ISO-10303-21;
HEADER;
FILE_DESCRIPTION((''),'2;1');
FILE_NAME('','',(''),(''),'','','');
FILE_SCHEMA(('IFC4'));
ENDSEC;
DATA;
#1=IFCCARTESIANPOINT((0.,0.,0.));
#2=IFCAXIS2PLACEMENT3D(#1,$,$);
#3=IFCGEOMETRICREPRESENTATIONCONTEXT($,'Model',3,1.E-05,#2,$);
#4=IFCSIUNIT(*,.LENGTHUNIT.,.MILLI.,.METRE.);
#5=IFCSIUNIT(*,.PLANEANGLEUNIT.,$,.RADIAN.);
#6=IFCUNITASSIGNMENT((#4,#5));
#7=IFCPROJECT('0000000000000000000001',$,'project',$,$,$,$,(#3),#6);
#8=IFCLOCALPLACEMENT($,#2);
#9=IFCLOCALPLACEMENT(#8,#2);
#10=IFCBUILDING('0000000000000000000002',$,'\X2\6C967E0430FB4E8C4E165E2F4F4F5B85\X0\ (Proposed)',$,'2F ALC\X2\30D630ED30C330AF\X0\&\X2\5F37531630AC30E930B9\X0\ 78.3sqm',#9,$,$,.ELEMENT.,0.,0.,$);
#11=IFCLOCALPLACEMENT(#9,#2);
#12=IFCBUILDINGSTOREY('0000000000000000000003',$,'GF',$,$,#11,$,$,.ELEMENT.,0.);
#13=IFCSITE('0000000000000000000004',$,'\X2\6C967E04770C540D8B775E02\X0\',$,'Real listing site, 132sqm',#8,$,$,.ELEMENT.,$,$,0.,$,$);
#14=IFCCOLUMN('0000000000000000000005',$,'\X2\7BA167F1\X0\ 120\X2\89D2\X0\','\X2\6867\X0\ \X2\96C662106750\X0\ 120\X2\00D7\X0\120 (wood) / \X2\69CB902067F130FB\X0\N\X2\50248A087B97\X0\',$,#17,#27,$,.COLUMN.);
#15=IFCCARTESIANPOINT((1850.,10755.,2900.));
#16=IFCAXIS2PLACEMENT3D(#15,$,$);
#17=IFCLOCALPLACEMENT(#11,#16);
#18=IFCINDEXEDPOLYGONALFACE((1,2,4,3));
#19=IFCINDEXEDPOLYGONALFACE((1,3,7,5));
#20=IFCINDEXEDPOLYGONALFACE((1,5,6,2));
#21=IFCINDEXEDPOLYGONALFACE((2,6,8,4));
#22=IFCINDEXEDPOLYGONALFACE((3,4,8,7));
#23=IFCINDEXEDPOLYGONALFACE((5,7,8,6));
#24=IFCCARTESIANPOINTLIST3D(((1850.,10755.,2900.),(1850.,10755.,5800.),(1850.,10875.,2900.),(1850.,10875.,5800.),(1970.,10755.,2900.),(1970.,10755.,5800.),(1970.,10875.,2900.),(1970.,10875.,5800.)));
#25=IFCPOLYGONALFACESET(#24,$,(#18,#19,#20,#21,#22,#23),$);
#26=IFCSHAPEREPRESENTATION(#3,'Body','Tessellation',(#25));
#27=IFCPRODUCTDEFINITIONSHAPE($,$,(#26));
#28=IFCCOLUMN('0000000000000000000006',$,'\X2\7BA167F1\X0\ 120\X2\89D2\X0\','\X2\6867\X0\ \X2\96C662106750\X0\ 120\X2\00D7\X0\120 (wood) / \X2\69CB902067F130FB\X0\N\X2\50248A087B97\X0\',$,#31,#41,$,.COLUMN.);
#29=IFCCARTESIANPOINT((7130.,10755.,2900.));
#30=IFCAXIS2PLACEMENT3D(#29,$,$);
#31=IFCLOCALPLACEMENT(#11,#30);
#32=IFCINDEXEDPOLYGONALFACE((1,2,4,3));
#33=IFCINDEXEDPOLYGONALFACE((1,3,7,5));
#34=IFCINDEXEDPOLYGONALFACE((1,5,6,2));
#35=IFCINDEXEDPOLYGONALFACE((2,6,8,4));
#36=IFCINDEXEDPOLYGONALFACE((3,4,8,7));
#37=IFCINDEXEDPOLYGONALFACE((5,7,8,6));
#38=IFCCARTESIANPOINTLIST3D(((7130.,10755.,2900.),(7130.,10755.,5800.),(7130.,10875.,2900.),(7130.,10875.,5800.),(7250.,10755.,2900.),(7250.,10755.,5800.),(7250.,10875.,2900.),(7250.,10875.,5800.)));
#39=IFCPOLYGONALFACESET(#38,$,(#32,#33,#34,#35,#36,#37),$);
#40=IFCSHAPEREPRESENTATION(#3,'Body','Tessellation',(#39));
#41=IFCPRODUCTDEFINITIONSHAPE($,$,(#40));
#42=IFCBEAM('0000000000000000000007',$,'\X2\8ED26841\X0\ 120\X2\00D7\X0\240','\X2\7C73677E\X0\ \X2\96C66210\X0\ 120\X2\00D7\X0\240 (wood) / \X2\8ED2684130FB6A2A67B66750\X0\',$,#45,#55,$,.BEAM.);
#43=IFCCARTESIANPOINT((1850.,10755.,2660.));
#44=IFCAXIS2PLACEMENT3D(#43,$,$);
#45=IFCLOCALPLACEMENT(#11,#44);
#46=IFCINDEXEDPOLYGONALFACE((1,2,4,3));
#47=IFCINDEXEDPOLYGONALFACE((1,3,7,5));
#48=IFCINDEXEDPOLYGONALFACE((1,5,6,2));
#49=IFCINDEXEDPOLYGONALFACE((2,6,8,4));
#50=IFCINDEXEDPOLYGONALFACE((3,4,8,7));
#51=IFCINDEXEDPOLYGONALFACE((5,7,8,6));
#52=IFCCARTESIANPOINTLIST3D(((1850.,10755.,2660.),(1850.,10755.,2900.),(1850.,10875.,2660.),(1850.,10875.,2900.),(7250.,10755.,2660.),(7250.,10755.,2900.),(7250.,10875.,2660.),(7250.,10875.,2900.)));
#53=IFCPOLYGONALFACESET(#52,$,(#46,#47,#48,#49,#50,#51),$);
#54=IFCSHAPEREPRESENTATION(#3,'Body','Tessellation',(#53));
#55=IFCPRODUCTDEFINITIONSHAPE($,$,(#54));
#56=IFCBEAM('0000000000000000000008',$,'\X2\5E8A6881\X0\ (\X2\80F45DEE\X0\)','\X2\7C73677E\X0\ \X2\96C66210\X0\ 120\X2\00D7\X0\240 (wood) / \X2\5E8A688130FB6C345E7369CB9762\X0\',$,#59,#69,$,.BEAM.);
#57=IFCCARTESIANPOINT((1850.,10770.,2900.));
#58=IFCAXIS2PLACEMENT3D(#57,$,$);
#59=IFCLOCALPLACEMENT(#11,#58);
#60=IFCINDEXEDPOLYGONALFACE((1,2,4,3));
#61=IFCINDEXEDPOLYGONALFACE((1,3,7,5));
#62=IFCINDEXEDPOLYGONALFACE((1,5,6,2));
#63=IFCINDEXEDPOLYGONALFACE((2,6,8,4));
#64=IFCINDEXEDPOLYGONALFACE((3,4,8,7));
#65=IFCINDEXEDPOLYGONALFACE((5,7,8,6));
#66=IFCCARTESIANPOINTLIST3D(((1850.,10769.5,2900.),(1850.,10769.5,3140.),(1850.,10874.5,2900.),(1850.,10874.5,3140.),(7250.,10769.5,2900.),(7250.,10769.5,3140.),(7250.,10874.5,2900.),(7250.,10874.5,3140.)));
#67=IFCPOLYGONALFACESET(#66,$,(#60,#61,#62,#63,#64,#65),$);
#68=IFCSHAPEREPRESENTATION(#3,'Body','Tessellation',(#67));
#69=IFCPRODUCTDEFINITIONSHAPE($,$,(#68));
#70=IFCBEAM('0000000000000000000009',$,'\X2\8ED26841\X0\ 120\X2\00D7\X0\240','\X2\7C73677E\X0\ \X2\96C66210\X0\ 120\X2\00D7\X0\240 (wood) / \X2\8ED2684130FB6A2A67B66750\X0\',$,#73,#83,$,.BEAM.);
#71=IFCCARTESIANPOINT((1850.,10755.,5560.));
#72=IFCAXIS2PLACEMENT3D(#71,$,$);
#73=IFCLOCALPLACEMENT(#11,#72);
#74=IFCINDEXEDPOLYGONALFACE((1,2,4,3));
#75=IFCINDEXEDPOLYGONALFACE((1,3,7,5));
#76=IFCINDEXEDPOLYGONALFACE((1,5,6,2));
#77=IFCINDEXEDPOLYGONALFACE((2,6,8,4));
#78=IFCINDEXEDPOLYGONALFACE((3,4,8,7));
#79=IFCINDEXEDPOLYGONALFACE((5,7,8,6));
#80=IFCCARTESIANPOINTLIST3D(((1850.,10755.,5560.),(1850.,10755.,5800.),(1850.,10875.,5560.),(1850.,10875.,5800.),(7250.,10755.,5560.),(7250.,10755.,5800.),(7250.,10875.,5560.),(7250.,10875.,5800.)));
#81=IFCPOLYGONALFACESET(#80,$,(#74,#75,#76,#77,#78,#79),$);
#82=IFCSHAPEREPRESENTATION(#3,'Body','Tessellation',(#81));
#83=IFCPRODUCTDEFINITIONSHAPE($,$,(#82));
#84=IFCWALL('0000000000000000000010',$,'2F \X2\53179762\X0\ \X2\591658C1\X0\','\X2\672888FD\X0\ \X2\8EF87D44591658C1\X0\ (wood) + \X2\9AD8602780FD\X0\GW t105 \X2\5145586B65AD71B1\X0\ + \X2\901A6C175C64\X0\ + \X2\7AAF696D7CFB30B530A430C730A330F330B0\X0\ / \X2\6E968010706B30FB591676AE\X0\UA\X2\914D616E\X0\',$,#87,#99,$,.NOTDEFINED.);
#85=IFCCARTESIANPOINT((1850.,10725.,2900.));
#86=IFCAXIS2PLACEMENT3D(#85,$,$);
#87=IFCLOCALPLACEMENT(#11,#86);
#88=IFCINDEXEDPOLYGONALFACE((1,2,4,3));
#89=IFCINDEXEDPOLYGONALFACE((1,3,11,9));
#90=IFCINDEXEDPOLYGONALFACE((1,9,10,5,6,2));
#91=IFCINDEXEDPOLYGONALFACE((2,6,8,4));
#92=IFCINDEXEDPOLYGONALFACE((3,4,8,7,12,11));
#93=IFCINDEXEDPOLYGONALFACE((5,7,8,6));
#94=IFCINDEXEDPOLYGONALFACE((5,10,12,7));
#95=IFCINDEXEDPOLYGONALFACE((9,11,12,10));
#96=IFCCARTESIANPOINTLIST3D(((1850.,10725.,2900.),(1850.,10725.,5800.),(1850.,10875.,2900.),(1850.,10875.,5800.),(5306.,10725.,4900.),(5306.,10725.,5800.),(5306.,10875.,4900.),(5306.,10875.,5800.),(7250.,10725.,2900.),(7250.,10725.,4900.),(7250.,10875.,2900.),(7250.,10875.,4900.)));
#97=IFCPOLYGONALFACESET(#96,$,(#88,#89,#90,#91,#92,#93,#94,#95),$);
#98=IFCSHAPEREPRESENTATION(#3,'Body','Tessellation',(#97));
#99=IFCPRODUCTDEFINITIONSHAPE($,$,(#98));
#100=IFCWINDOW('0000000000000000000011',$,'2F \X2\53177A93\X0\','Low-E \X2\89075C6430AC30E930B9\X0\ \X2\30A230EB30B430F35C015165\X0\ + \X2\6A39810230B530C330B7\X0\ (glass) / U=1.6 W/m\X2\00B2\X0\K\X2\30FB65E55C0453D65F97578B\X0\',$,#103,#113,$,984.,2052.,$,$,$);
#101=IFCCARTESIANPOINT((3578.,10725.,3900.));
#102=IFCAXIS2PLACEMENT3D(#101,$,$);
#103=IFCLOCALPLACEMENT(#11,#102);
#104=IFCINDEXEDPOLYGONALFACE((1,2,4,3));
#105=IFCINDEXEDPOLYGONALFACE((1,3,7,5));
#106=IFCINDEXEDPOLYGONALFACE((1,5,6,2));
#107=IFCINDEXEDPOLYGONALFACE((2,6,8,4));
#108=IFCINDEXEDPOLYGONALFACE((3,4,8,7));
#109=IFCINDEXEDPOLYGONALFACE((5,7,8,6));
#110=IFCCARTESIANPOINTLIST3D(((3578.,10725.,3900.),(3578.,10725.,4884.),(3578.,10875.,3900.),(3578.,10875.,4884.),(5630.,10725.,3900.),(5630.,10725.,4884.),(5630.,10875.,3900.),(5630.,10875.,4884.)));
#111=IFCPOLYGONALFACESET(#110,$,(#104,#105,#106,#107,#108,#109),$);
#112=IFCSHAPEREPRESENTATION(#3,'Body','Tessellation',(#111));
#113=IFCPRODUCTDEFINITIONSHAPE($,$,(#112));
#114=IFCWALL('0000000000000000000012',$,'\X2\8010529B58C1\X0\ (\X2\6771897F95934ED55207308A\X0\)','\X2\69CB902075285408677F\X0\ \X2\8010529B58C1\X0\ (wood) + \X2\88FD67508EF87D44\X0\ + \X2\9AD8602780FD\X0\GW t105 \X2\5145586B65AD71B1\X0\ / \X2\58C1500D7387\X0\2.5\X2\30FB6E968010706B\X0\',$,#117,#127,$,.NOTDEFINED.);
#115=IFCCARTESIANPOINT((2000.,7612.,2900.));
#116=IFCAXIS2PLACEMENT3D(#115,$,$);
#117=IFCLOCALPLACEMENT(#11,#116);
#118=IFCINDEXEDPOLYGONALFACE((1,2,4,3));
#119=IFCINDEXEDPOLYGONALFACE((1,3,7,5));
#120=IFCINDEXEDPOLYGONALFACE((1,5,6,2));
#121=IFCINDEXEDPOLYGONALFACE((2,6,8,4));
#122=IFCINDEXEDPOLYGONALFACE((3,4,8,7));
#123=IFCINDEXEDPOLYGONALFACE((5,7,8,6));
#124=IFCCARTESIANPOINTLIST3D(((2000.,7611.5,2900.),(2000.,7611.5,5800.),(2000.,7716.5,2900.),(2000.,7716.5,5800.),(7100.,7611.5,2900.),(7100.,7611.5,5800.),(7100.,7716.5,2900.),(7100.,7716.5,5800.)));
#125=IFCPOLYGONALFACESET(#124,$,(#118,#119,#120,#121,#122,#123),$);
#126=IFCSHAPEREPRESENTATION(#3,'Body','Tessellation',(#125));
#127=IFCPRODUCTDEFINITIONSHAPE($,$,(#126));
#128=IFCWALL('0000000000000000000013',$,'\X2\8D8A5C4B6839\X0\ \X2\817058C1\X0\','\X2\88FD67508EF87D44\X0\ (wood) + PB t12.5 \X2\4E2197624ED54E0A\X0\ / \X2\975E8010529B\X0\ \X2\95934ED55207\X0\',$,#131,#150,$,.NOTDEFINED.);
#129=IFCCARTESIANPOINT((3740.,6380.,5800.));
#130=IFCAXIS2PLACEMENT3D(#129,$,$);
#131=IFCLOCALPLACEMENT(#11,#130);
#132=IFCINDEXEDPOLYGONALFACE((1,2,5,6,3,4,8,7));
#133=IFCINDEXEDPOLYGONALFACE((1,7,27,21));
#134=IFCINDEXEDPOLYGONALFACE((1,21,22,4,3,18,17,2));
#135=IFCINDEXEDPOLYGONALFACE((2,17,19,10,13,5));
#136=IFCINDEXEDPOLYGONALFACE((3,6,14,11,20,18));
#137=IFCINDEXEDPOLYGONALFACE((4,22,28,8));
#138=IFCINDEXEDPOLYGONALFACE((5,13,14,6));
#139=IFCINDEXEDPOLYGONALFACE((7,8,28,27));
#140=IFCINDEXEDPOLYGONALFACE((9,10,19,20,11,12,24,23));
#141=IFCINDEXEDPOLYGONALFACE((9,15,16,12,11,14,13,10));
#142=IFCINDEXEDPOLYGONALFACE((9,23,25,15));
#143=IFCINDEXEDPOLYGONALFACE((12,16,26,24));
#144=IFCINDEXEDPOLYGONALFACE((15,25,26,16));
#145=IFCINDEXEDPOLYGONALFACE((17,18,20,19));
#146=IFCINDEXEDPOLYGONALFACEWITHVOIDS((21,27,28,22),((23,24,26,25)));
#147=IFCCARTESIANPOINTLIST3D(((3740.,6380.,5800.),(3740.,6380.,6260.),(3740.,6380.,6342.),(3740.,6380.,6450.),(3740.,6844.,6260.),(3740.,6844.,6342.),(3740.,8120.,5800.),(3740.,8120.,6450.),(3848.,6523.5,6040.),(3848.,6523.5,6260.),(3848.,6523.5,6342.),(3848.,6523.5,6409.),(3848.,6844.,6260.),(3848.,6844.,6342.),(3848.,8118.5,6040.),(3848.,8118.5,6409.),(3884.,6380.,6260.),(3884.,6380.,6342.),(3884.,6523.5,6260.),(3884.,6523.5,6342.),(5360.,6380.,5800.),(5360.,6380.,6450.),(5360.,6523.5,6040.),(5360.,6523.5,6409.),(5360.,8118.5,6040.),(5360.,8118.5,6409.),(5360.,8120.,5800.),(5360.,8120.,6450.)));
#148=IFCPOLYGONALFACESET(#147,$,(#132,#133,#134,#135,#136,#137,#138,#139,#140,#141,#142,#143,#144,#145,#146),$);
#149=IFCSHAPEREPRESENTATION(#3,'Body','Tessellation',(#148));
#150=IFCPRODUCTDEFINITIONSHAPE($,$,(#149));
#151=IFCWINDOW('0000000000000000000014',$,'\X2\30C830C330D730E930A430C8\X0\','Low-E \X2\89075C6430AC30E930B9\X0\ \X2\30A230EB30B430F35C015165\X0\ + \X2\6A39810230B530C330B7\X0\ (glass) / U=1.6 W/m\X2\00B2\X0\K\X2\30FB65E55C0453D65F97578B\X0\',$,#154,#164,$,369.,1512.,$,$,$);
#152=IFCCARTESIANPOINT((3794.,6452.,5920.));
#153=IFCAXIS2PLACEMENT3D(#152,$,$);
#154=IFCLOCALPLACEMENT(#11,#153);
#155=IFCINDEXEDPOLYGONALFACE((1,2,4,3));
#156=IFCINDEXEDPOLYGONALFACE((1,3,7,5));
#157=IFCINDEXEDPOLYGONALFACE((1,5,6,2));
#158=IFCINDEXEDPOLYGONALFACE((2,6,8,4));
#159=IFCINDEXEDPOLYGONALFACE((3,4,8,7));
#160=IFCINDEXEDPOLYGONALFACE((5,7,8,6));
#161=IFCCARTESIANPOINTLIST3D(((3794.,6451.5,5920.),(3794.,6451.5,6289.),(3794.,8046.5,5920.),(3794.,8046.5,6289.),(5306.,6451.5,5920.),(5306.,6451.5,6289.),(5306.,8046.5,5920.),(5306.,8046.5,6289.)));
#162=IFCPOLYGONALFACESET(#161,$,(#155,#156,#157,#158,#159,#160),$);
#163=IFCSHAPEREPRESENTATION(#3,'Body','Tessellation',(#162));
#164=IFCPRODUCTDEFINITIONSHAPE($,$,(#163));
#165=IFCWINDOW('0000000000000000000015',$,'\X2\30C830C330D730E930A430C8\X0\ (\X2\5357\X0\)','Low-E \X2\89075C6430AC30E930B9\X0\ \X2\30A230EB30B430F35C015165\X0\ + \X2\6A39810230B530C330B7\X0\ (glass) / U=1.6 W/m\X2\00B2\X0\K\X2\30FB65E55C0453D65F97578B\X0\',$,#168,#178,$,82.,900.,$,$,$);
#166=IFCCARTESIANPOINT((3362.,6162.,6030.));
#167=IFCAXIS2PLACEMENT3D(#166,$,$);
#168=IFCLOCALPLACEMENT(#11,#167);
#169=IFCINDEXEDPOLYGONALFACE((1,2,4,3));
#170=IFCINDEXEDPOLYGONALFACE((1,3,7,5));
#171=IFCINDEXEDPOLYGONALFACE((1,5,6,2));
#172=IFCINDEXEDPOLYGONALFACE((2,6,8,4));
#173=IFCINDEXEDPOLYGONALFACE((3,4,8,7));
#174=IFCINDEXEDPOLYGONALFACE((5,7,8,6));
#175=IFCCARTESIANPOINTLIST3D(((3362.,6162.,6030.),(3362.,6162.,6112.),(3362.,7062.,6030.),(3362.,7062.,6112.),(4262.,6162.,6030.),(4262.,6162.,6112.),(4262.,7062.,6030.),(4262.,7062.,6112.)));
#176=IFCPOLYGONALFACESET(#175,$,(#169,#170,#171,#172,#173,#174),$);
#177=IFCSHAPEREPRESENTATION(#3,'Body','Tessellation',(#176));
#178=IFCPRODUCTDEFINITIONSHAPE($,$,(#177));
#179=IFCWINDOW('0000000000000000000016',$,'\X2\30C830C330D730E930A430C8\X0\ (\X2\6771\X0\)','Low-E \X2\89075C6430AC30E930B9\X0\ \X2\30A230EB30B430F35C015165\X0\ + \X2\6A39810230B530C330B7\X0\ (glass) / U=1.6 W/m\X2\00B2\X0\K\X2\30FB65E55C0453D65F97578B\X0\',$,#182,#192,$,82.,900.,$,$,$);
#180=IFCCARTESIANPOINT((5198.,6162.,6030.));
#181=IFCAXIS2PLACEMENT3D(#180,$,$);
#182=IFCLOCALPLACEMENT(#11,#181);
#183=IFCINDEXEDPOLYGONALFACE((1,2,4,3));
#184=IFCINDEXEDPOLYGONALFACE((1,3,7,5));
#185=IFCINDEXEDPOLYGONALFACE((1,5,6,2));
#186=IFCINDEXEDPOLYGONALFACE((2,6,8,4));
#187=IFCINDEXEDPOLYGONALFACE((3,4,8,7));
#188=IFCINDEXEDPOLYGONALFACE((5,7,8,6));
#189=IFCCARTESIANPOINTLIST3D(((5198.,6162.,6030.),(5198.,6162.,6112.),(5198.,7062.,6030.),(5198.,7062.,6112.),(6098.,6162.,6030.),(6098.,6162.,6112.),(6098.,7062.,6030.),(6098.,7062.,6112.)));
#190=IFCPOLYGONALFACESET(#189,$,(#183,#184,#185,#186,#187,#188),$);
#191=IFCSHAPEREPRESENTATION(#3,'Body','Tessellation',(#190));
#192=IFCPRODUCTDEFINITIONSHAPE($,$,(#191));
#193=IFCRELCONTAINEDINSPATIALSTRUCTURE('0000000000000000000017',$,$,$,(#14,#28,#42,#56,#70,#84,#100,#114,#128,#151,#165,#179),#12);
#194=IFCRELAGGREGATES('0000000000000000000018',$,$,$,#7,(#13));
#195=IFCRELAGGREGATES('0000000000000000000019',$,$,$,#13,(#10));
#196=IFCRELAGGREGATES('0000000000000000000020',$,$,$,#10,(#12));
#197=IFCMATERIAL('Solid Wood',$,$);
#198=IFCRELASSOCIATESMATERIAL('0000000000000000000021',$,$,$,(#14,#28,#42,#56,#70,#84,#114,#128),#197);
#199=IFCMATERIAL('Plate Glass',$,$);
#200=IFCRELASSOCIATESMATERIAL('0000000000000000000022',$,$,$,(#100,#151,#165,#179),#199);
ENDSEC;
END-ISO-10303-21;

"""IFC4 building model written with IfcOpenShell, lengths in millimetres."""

from ifc_helpers import new_model, si_unit, frame, frame_2d, origin, place, context, project, spatial, rectangle, extrude, material, element, fill, save


model = new_model("IFC4")

# Units and contexts
model_context = context("Model", 3, precision=1e-05, world=origin())
ifc_project = project(units=[si_unit("LENGTHUNIT", "METRE", prefix="MILLI"), si_unit("PLANEANGLEUNIT", "RADIAN")], contexts=[model_context])

# Site, building, storey
site_placement = place(None, origin())
site = spatial("IfcSite", under=ifc_project, at=site_placement, Name="沖縄県名護市", ObjectType="Real listing site, 132sqm", CompositionType="ELEMENT", RefElevation=0.0)
building_placement = place(site_placement, origin())
building = spatial("IfcBuilding", under=site, at=building_placement, Name="沖縄・二世帯住宅 (Proposed)", ObjectType="2F ALCブロック&強化ガラス 78.3sqm", CompositionType="ELEMENT", ElevationOfRefHeight=0.0, ElevationOfTerrain=0.0)
storey_placement = place(building_placement, origin())
storey = spatial("IfcBuildingStorey", under=building, at=storey_placement, Name="GF", CompositionType="ELEMENT", Elevation=0.0)

# Columns
ifc_material_1 = material(Name="Solid Wood")
column_1_placement = place(storey_placement, frame((1850.0, 10755.0, 2900.0)))
element("IfcColumn", 1, at=column_1_placement, inside=storey, material=ifc_material_1, Name="管柱 120角", Description="桧 集成材 120×120 (wood) / 構造柱・N値計算", PredefinedType="COLUMN", context=model_context, shape_type="SweptSolid", body=[
    extrude(rectangle(XDim=120.0, YDim=120.0, at=frame_2d((60.0, 60.0))), frame((1850.0, 10755.0, 2900.0)), (0.0, 0.0, 1.0), 2900.0),
])
column_2_placement = place(storey_placement, frame((7130.0, 10755.0, 2900.0)))
element("IfcColumn", 2, at=column_2_placement, inside=storey, material=ifc_material_1, Name="管柱 120角", Description="桧 集成材 120×120 (wood) / 構造柱・N値計算", PredefinedType="COLUMN", context=model_context, shape_type="SweptSolid", body=[
    extrude(rectangle(XDim=120.0, YDim=120.0, at=frame_2d((60.0, 60.0))), frame((7130.0, 10755.0, 2900.0)), (0.0, 0.0, 1.0), 2900.0),
])

# Beams
beam_1_placement = place(storey_placement, frame((1850.0, 10755.0, 2660.0)))
element("IfcBeam", 3, at=beam_1_placement, inside=storey, material=ifc_material_1, Name="軒桁 120×240", Description="米松 集成 120×240 (wood) / 軒桁・横架材", PredefinedType="BEAM", context=model_context, shape_type="SweptSolid", body=[
    extrude(rectangle(XDim=5400.0, YDim=120.0, at=frame_2d((2700.0, 60.0))), frame((1850.0, 10755.0, 2660.0)), (0.0, 0.0, 1.0), 240.0),
])
beam_2_placement = place(storey_placement, frame((1850.0, 10770.0, 2900.0)))
element("IfcBeam", 4, at=beam_2_placement, inside=storey, material=ifc_material_1, Name="床梁 (胴差)", Description="米松 集成 120×240 (wood) / 床梁・水平構面", PredefinedType="BEAM", context=model_context, shape_type="SweptSolid", body=[
    extrude(rectangle(XDim=5400.0, YDim=105.0, at=frame_2d((2700.0, 52.0))), frame((1850.0, 10770.0, 2900.0)), (0.0, 0.0, 1.0), 240.0),
])
beam_3_placement = place(storey_placement, frame((1850.0, 10755.0, 5560.0)))
element("IfcBeam", 5, at=beam_3_placement, inside=storey, material=ifc_material_1, Name="軒桁 120×240", Description="米松 集成 120×240 (wood) / 軒桁・横架材", PredefinedType="BEAM", context=model_context, shape_type="SweptSolid", body=[
    extrude(rectangle(XDim=5400.0, YDim=120.0, at=frame_2d((2700.0, 60.0))), frame((1850.0, 10755.0, 5560.0)), (0.0, 0.0, 1.0), 240.0),
])

# Wall, opening, window
wall_1_placement = place(storey_placement, frame((1850.0, 10725.0, 2900.0)))
wall_1 = element("IfcWall", 6, at=wall_1_placement, inside=storey, material=ifc_material_1, Name="2F 北面 外壁", Description="木製 軸組外壁 (wood) + 高性能GW t105 充填断熱 + 通気層 + 窯業系サイディング / 準耐火・外皮UA配慮", PredefinedType="NOTDEFINED", context=model_context, shape_type="SweptSolid", body=[
    extrude(rectangle(XDim=5400.0, YDim=150.0, at=frame_2d((2700.0, 75.0))), frame((1850.0, 10725.0, 2900.0)), (0.0, 0.0, 1.0), 2900.0),
])
opening_1_placement = place(storey_placement, frame((3578.0, 10725.0, 3900.0)))
opening_1 = element("IfcOpeningElement", 7, at=opening_1_placement, cuts=wall_1, PredefinedType="NOTDEFINED", context=model_context, shape_type="SweptSolid", body=[
    extrude(rectangle(XDim=2052.0, YDim=150.0, at=frame_2d((1026.0, 75.0))), frame((3578.0, 10725.0, 3900.0)), (0.0, 0.0, 1.0), 984.0),
])
ifc_material_2 = material(Name="Plate Glass")
window_1_placement = place(storey_placement, frame((3578.0, 10725.0, 3900.0)))
window_1 = element("IfcWindow", 8, at=window_1_placement, inside=storey, material=ifc_material_2, Name="2F 北窓", Description="Low-E 複層ガラス アルゴン封入 + 樹脂サッシ (glass) / U=1.6 W/m²K・日射取得型", OverallHeight=984.0, OverallWidth=2052.0, context=model_context, shape_type="SweptSolid", body=[
    extrude(rectangle(XDim=2052.0, YDim=150.0, at=frame_2d((1026.0, 75.0))), frame((3578.0, 10725.0, 3900.0)), (0.0, 0.0, 1.0), 984.0),
])
fill(opening_1, window_1)

# Wall
wall_2_placement = place(storey_placement, frame((2000.0, 7612.0, 2900.0)))
element("IfcWall", 9, at=wall_2_placement, inside=storey, material=ifc_material_1, Name="耐力壁 (東西間仕切り)", Description="構造用合板 耐力壁 (wood) + 製材軸組 + 高性能GW t105 充填断熱 / 壁倍率2.5・準耐火", PredefinedType="NOTDEFINED", context=model_context, shape_type="SweptSolid", body=[
    extrude(rectangle(XDim=5100.0, YDim=105.0, at=frame_2d((2550.0, 52.0))), frame((2000.0, 7612.0, 2900.0)), (0.0, 0.0, 1.0), 2900.0),
])

# Wall, openings, windows
wall_3_placement = place(storey_placement, frame((3740.0, 6380.0, 5800.0)))
wall_3 = element("IfcWall", 10, at=wall_3_placement, inside=storey, material=ifc_material_1, Name="越屋根 腰壁", Description="製材軸組 (wood) + PB t12.5 両面仕上 / 非耐力 間仕切", PredefinedType="NOTDEFINED", context=model_context, shape_type="SweptSolid", body=[
    extrude(rectangle(XDim=1620.0, YDim=1740.0, at=frame_2d((810.0, 870.0))), frame((3740.0, 6380.0, 5800.0)), (0.0, 0.0, 1.0), 650.0),
])
opening_2_placement = place(storey_placement, frame((3794.0, 6452.0, 5920.0)))
opening_2 = element("IfcOpeningElement", 11, at=opening_2_placement, cuts=wall_3, PredefinedType="NOTDEFINED", context=model_context, shape_type="SweptSolid", body=[
    extrude(rectangle(XDim=1512.0, YDim=1595.0, at=frame_2d((756.0, 797.0))), frame((3794.0, 6452.0, 5920.0)), (0.0, 0.0, 1.0), 369.0),
])
opening_3_placement = place(storey_placement, frame((3362.0, 6162.0, 6030.0)))
opening_3 = element("IfcOpeningElement", 12, at=opening_3_placement, cuts=wall_3, PredefinedType="NOTDEFINED", context=model_context, shape_type="SweptSolid", body=[
    extrude(rectangle(XDim=900.0, YDim=900.0, at=frame_2d((450.0, 450.0))), frame((3362.0, 6162.0, 6030.0)), (0.0, 0.0, 1.0), 82.0),
])
opening_4_placement = place(storey_placement, frame((5198.0, 6162.0, 6030.0)))
opening_4 = element("IfcOpeningElement", 13, at=opening_4_placement, cuts=wall_3, PredefinedType="NOTDEFINED", context=model_context, shape_type="SweptSolid", body=[
    extrude(rectangle(XDim=900.0, YDim=900.0, at=frame_2d((450.0, 450.0))), frame((5198.0, 6162.0, 6030.0)), (0.0, 0.0, 1.0), 82.0),
])
window_2_placement = place(storey_placement, frame((3794.0, 6452.0, 5920.0)))
window_2 = element("IfcWindow", 14, at=window_2_placement, inside=storey, material=ifc_material_2, Name="トップライト", Description="Low-E 複層ガラス アルゴン封入 + 樹脂サッシ (glass) / U=1.6 W/m²K・日射取得型", OverallHeight=369.0, OverallWidth=1512.0, context=model_context, shape_type="SweptSolid", body=[
    extrude(rectangle(XDim=1512.0, YDim=1595.0, at=frame_2d((756.0, 797.0))), frame((3794.0, 6452.0, 5920.0)), (0.0, 0.0, 1.0), 369.0),
])
fill(opening_2, window_2)
window_3_placement = place(storey_placement, frame((3362.0, 6162.0, 6030.0)))
window_3 = element("IfcWindow", 15, at=window_3_placement, inside=storey, material=ifc_material_2, Name="トップライト (南)", Description="Low-E 複層ガラス アルゴン封入 + 樹脂サッシ (glass) / U=1.6 W/m²K・日射取得型", OverallHeight=82.0, OverallWidth=900.0, context=model_context, shape_type="SweptSolid", body=[
    extrude(rectangle(XDim=900.0, YDim=900.0, at=frame_2d((450.0, 450.0))), frame((3362.0, 6162.0, 6030.0)), (0.0, 0.0, 1.0), 82.0),
])
fill(opening_3, window_3)
window_4_placement = place(storey_placement, frame((5198.0, 6162.0, 6030.0)))
window_4 = element("IfcWindow", 16, at=window_4_placement, inside=storey, material=ifc_material_2, Name="トップライト (東)", Description="Low-E 複層ガラス アルゴン封入 + 樹脂サッシ (glass) / U=1.6 W/m²K・日射取得型", OverallHeight=82.0, OverallWidth=900.0, context=model_context, shape_type="SweptSolid", body=[
    extrude(rectangle(XDim=900.0, YDim=900.0, at=frame_2d((450.0, 450.0))), frame((5198.0, 6162.0, 6030.0)), (0.0, 0.0, 1.0), 82.0),
])
fill(opening_4, window_4)

save(model, "model.ifc")
